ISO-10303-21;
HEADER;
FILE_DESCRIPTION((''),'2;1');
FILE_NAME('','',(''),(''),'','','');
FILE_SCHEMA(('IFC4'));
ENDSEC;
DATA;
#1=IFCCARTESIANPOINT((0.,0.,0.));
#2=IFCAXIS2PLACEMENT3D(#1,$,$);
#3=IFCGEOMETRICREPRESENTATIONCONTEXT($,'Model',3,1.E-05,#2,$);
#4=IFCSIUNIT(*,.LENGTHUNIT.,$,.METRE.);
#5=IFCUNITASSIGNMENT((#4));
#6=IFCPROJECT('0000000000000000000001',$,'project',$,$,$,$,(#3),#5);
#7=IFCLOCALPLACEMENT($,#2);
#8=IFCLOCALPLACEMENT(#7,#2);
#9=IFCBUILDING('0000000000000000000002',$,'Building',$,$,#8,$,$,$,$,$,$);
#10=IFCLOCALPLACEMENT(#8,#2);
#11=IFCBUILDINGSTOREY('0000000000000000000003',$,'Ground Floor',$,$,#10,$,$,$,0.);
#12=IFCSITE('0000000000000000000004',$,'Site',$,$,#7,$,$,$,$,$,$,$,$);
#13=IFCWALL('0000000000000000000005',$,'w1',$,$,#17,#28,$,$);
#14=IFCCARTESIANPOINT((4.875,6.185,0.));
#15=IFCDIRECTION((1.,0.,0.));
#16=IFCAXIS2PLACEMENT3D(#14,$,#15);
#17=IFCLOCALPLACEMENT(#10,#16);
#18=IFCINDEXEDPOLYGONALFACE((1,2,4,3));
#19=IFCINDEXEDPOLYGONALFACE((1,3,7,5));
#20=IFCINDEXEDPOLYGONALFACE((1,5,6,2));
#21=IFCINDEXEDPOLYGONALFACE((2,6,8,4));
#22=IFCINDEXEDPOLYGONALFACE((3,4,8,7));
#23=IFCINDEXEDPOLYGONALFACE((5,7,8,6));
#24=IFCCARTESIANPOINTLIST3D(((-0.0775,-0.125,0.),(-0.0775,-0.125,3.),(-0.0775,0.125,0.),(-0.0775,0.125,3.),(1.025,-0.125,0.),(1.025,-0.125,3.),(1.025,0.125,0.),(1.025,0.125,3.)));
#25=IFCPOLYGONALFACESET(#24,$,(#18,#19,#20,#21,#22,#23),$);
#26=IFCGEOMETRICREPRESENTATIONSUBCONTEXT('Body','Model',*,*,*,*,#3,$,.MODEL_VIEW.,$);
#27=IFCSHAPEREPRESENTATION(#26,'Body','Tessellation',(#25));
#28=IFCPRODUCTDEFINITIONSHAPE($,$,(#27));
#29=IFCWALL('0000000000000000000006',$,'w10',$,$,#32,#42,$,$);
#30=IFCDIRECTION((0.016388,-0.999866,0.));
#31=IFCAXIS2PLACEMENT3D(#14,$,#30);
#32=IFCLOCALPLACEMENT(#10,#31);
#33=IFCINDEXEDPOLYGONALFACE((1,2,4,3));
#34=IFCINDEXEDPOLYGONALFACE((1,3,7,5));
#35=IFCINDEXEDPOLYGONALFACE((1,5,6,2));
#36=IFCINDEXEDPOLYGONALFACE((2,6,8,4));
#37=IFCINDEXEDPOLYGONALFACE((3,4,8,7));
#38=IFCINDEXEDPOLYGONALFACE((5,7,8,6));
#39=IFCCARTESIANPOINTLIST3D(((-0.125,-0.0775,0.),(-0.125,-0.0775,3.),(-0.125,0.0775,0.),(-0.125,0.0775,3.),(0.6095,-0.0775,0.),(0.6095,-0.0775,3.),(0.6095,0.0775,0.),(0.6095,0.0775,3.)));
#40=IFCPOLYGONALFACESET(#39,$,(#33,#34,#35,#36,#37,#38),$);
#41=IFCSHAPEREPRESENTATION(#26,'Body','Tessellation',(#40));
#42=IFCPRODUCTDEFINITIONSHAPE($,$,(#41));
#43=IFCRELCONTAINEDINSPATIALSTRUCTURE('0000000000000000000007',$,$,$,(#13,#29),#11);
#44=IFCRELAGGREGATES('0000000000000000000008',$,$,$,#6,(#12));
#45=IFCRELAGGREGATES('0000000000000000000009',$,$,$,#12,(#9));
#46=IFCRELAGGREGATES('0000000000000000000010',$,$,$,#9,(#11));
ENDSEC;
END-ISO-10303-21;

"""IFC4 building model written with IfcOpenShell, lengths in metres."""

from ifc_helpers import new_model, si_unit, frame, origin, place, context, subcontext, project, spatial, polyline, outline, extrude, element, save


model = new_model("IFC4")

# Units and contexts
model_context = context("Model", 3, precision=1e-05, world=origin())
body_context = subcontext(model_context, "Body", "Model", "MODEL_VIEW")
ifc_project = project(units=[si_unit("LENGTHUNIT", "METRE")], contexts=[model_context])

# Site, building, storey
site_placement = place(None, origin())
site = spatial("IfcSite", under=ifc_project, at=site_placement, Name="Site")
building_placement = place(site_placement, origin())
building = spatial("IfcBuilding", under=site, at=building_placement, Name="Building")
storey_placement = place(building_placement, origin())
storey = spatial("IfcBuildingStorey", under=building, at=storey_placement, Name="Ground Floor", Elevation=0.0)

# Wall
wall_1_placement = place(storey_placement, frame((4.875, 6.185, 0.0), x_axis=(1.0, 0.0, 0.0)))
element("IfcWall", 1, at=wall_1_placement, inside=storey, Name="w1", context=body_context, shape_type="SweptSolid", body=[
    extrude(outline(polyline([(-0.0775, -0.125), (1.025, -0.125), (1.025, 0.125), (-0.0775, 0.125), (-0.0775, -0.125)])), origin(), (0.0, 0.0, 1.0), 3.0),
])

# Wall
wall_2_placement = place(storey_placement, frame((4.875, 6.185, 0.0), x_axis=(0.016388, -0.999866, 0.0)))
element("IfcWall", 2, at=wall_2_placement, inside=storey, Name="w10", context=body_context, shape_type="SweptSolid", body=[
    extrude(outline(polyline([(-0.125, -0.0775), (0.6095, -0.0775), (0.6095, 0.0775), (-0.125, 0.0775), (-0.125, -0.0775)])), origin(), (0.0, 0.0, 1.0), 3.0),
])

save(model, "model.ifc")
